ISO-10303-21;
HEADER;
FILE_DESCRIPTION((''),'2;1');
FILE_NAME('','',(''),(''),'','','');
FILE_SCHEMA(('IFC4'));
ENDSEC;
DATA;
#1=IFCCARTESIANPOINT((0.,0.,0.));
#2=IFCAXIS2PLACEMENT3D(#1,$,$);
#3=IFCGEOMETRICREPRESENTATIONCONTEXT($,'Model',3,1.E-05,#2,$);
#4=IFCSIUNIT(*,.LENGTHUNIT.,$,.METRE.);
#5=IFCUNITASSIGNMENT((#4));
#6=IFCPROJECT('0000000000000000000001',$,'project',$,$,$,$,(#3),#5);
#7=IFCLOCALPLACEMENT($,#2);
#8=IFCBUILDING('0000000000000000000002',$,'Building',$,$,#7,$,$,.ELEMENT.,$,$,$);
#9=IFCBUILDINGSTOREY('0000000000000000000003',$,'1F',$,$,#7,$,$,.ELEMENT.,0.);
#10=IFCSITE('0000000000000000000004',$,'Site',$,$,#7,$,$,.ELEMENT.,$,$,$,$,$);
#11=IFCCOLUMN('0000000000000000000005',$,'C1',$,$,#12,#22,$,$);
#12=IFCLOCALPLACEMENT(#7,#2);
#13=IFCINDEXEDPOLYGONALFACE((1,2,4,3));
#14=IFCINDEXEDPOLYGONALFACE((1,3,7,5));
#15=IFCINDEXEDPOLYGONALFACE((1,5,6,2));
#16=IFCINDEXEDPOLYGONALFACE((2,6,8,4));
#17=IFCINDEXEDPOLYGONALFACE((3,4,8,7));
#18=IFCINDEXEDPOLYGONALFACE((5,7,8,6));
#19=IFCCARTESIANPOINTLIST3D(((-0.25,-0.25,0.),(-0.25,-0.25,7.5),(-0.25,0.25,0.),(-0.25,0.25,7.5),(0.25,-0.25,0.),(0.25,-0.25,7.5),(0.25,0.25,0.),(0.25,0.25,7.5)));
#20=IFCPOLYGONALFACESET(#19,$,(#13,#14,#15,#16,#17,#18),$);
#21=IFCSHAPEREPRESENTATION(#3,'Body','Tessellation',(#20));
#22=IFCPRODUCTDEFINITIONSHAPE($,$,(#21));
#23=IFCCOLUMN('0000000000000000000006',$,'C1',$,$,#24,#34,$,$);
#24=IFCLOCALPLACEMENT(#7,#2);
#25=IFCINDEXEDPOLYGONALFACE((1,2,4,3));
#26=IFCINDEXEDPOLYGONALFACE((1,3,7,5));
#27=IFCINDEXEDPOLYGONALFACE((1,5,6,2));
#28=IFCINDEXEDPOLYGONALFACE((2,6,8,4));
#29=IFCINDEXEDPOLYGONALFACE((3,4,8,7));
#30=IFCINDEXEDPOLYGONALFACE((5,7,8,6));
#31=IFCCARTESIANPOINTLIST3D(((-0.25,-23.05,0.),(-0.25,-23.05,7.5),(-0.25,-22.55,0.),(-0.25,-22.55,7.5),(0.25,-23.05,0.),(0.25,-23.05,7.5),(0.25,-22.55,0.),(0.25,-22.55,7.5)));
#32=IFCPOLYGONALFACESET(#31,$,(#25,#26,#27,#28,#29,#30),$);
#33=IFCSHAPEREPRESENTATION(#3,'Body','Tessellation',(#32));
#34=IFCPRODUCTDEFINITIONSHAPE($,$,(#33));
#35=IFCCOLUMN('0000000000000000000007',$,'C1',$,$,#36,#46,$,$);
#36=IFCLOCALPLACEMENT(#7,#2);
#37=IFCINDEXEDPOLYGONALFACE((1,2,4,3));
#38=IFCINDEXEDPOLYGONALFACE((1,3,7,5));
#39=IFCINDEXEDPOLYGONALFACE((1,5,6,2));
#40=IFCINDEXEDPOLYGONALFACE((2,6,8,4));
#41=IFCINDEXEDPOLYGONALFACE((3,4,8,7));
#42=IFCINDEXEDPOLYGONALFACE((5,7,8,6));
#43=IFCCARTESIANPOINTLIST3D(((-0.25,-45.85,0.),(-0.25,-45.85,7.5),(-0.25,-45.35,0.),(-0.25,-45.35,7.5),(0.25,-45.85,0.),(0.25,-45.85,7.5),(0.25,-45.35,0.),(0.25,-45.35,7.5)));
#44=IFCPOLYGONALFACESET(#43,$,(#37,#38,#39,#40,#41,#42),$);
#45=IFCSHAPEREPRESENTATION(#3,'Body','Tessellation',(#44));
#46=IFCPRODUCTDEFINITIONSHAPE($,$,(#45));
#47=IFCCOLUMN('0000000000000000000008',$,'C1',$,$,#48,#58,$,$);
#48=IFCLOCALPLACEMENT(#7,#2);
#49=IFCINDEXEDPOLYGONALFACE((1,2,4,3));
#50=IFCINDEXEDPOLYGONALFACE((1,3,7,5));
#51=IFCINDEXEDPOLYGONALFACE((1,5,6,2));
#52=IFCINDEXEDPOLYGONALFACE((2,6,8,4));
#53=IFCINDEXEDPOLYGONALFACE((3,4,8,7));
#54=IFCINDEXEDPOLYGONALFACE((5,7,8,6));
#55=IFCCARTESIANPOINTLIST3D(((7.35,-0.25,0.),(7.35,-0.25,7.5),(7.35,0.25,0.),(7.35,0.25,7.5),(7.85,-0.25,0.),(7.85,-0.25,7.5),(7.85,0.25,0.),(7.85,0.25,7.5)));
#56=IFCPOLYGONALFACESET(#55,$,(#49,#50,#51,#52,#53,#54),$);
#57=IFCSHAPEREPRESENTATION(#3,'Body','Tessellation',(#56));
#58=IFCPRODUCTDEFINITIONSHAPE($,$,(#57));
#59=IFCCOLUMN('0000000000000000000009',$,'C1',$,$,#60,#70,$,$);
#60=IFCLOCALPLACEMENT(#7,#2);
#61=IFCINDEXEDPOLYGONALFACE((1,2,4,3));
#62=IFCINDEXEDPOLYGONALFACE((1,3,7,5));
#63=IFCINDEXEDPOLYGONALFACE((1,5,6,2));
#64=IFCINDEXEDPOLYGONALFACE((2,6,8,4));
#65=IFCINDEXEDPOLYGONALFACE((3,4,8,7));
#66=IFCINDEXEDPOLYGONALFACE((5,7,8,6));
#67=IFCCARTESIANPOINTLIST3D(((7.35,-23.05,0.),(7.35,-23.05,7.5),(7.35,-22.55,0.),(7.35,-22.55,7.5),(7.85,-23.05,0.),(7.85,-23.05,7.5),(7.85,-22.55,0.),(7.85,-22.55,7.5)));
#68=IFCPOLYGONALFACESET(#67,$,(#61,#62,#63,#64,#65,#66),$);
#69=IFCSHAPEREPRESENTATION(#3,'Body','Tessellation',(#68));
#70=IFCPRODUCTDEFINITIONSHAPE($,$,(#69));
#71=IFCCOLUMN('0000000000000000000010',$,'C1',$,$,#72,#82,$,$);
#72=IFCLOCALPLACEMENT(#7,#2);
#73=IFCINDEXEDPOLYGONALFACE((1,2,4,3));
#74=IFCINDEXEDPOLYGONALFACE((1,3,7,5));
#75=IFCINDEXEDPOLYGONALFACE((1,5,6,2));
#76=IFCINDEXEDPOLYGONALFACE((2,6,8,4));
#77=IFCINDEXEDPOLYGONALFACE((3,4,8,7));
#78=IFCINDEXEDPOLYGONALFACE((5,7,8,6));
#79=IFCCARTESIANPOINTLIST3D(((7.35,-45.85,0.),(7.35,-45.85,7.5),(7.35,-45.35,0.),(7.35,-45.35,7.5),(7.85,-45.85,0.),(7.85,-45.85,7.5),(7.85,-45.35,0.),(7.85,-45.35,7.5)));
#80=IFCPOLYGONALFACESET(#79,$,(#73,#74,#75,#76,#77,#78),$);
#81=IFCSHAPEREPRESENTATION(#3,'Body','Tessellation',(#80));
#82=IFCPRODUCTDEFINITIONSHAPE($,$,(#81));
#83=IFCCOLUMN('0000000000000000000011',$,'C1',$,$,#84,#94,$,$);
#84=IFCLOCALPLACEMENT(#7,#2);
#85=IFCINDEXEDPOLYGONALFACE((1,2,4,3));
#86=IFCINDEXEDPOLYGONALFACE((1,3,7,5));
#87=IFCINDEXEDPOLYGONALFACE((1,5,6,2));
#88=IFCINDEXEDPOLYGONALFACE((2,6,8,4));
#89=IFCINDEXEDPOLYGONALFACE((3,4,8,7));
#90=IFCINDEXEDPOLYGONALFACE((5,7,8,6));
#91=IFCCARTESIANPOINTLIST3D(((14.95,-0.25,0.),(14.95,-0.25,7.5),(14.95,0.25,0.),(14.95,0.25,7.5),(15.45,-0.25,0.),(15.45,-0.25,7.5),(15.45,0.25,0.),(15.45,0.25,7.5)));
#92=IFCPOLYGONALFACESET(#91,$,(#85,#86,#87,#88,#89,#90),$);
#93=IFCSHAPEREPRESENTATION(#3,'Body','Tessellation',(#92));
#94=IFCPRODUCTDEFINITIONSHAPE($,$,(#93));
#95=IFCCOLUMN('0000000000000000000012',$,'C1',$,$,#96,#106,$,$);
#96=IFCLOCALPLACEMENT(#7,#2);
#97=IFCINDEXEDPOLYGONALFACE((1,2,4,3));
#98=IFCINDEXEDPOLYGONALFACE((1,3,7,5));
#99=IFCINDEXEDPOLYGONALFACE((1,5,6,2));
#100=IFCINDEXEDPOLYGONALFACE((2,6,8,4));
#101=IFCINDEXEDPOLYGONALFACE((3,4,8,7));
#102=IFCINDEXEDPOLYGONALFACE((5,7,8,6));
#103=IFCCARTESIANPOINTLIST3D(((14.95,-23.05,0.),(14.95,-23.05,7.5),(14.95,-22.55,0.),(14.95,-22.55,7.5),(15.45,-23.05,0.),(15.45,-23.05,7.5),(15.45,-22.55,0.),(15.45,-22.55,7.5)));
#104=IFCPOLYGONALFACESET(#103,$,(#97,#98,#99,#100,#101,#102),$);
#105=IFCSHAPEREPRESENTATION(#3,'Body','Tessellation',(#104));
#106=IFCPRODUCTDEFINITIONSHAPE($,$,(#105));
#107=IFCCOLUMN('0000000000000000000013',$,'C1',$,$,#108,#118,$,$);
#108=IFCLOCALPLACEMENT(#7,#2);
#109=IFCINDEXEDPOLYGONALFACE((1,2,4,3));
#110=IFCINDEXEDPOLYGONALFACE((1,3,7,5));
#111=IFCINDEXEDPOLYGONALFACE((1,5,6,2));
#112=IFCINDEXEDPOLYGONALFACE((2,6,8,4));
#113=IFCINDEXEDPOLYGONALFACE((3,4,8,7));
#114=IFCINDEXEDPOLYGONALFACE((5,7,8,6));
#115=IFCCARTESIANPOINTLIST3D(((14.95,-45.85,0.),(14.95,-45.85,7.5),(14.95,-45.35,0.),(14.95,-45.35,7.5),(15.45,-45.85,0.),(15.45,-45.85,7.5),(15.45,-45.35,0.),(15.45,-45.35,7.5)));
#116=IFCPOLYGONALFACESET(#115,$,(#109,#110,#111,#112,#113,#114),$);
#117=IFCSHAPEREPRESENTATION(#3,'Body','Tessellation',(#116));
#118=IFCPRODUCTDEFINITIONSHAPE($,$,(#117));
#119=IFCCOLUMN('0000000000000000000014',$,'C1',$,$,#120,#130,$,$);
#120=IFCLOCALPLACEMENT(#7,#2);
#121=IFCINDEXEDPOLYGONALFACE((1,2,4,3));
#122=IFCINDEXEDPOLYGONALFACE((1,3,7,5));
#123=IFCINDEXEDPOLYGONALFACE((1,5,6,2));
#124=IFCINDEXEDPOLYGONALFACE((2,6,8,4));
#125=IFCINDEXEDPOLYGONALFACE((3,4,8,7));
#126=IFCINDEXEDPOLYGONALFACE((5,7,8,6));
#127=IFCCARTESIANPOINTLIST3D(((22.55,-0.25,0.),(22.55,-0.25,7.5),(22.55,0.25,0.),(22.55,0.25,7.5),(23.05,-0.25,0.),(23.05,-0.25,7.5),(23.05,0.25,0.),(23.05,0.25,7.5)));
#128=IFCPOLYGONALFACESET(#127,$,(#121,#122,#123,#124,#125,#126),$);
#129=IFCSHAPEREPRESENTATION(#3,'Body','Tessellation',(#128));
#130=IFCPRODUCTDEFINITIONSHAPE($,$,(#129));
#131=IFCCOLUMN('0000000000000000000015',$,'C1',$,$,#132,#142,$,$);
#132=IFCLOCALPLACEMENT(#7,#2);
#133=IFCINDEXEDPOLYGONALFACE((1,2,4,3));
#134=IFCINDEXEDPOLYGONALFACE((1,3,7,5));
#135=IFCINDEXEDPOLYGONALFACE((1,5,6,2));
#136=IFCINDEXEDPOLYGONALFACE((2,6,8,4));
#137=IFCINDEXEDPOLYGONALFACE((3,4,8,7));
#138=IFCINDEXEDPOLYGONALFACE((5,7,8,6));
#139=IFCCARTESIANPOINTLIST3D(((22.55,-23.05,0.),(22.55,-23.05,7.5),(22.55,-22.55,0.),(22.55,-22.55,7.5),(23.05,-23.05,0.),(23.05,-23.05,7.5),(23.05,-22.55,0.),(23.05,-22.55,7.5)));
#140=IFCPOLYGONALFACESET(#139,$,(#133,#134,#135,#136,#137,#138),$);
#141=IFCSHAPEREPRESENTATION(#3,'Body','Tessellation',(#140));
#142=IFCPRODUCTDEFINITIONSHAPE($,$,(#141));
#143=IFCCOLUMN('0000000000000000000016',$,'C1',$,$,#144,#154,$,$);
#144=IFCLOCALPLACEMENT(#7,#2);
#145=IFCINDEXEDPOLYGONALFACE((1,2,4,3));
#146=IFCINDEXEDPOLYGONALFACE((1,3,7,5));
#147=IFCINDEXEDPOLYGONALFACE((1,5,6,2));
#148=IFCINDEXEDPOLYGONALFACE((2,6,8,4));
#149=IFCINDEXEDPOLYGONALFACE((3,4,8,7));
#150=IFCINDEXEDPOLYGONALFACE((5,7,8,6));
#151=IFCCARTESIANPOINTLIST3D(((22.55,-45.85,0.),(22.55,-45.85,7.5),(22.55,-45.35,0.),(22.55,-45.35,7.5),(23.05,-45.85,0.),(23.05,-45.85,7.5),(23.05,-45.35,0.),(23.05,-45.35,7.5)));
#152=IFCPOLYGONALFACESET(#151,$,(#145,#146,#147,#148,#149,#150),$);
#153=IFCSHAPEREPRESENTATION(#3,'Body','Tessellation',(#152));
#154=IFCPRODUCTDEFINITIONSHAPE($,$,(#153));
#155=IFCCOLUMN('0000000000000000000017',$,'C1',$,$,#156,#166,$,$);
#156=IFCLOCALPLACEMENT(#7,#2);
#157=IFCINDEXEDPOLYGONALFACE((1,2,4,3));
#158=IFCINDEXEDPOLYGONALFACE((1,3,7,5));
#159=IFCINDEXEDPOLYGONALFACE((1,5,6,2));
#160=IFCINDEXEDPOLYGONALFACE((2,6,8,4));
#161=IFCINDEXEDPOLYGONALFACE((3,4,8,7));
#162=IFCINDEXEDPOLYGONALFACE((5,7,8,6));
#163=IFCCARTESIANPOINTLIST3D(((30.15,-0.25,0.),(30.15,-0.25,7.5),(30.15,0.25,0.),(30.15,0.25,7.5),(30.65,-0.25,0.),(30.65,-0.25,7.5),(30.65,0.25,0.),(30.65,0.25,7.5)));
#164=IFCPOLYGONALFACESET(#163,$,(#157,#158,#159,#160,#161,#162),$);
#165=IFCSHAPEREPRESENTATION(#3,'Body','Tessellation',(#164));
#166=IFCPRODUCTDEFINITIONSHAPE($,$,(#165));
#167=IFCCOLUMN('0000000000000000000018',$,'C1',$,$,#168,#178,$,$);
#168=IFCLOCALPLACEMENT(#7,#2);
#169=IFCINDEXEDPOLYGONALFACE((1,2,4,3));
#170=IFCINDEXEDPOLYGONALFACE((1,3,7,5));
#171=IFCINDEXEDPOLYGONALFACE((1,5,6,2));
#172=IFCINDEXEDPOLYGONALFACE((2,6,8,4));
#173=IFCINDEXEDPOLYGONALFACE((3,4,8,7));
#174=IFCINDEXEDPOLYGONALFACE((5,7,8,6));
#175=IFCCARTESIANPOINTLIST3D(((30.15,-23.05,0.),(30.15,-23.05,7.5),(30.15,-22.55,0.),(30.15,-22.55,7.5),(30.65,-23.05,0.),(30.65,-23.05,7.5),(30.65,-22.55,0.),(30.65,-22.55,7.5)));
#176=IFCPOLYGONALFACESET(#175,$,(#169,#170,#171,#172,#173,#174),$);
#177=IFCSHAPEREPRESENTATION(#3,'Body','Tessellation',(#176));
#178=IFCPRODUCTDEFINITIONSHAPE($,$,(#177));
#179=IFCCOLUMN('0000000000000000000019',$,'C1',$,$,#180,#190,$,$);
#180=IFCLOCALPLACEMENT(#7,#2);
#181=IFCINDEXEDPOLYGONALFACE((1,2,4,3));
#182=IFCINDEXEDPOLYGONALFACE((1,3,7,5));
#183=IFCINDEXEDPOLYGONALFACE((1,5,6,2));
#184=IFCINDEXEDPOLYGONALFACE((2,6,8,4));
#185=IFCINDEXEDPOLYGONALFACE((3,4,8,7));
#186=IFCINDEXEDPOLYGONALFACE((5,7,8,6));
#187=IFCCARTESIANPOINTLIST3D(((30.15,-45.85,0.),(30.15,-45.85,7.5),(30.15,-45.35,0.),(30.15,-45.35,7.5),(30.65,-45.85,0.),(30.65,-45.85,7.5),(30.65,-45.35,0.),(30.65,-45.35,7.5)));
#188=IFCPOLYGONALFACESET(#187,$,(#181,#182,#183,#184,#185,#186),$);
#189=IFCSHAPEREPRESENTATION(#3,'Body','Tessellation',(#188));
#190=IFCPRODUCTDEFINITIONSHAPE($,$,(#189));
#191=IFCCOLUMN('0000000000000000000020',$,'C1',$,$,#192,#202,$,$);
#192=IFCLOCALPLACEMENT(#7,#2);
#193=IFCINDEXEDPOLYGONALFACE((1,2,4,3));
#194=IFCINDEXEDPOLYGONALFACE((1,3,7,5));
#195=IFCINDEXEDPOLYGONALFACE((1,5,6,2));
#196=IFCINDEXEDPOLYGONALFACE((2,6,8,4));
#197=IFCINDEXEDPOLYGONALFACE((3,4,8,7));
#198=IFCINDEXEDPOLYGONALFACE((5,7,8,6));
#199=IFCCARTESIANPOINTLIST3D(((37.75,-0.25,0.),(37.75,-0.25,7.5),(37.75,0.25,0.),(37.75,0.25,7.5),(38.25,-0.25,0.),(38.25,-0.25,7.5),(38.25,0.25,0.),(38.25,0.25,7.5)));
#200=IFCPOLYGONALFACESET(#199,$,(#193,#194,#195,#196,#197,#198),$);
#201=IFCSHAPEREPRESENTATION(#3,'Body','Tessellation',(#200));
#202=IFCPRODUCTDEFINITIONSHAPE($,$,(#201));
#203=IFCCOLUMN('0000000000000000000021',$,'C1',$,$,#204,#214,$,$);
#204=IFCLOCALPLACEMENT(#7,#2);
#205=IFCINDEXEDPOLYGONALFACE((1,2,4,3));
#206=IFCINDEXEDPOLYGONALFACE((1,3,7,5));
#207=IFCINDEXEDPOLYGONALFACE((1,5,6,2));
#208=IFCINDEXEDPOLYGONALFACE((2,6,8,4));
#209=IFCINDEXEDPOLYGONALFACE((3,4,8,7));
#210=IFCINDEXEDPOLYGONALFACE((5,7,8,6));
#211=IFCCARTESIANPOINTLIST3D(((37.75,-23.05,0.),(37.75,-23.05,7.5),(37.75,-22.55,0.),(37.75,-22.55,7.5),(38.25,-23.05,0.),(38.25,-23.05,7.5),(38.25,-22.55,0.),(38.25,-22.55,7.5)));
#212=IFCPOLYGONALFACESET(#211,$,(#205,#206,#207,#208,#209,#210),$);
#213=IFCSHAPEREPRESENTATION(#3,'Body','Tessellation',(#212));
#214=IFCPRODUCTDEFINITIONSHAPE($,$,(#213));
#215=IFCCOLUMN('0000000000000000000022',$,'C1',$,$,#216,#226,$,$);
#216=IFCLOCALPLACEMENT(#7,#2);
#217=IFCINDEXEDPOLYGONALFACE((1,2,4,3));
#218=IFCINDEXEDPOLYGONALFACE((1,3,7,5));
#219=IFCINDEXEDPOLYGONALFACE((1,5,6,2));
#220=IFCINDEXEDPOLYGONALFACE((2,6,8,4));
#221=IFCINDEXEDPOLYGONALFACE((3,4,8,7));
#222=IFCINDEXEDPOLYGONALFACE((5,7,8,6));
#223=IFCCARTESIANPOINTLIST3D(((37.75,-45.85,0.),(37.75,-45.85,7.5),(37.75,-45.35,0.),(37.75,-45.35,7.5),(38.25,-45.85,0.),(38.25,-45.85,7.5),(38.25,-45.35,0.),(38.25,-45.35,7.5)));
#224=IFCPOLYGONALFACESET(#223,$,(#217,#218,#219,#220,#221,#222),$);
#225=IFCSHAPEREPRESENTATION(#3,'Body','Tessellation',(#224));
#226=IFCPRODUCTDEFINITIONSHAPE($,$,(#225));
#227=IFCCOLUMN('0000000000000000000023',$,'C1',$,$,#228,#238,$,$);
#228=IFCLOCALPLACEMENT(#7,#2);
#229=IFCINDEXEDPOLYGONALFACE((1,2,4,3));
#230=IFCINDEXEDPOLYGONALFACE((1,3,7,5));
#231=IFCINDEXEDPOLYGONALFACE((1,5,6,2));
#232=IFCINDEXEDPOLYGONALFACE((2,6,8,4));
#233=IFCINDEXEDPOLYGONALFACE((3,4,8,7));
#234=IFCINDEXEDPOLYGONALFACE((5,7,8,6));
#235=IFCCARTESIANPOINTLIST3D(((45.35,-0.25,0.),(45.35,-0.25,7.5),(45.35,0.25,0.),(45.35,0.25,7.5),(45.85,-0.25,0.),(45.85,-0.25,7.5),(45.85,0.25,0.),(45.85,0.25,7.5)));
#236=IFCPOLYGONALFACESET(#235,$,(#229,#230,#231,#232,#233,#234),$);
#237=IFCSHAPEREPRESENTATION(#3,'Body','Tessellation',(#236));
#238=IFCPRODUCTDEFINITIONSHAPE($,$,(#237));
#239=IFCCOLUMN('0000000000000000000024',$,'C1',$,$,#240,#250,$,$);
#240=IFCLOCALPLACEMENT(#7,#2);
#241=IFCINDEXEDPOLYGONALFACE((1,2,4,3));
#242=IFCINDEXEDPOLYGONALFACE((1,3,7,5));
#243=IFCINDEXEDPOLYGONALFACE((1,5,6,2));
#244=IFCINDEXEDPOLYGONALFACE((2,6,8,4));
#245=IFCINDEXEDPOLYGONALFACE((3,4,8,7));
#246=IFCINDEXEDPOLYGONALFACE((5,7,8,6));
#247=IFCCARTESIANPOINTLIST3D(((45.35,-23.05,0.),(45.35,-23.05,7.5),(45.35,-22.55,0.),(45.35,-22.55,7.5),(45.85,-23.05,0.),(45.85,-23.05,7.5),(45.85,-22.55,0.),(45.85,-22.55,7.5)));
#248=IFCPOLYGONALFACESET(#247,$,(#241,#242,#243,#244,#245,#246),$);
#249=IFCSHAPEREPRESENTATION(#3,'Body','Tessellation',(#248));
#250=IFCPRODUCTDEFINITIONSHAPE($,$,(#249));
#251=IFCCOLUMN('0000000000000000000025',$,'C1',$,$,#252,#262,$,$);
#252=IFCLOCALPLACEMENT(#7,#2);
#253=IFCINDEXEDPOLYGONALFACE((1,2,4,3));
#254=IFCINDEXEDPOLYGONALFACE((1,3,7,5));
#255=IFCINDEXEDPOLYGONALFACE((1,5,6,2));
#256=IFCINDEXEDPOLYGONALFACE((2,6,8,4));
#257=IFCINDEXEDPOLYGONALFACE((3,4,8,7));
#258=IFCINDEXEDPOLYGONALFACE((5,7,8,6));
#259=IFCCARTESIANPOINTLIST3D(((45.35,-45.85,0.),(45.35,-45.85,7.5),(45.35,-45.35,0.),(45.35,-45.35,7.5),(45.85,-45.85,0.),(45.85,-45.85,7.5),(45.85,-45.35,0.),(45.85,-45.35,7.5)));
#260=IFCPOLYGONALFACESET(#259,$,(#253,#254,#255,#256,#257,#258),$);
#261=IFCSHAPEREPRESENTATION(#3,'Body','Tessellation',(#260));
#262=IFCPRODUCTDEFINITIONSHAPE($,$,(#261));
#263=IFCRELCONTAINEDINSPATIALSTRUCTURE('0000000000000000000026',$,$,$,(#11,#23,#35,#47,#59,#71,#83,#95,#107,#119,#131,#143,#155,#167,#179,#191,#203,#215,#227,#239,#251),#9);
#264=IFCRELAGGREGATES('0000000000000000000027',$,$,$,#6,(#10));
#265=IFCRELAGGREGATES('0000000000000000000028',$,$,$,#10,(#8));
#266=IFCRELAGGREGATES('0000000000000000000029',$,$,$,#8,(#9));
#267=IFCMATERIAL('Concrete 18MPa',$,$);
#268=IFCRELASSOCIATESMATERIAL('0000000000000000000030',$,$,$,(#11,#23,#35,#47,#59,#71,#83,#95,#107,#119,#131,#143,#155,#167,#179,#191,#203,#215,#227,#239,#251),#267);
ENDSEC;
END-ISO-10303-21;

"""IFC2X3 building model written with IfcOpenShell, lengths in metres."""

from ifc_helpers import new_model, si_unit, frame, origin, origin_2d, place, context, project, spatial, rectangle, extrude, material, element, save


model = new_model("IFC2X3")

# Units and contexts
model_context = context("Model", 3, precision=1e-05, world=origin())
ifc_project = project(units=[si_unit("LENGTHUNIT", "METRE")], contexts=[model_context])

# Site, building, storey
placement = place(None, origin())
site = spatial("IfcSite", under=ifc_project, at=placement, Name="Site", CompositionType="ELEMENT")
building = spatial("IfcBuilding", under=site, at=placement, Name="Building", CompositionType="ELEMENT")
storey = spatial("IfcBuildingStorey", under=building, at=placement, Name="1F", CompositionType="ELEMENT", Elevation=0.0)

# Columns
ifc_material = material(Name="Concrete 18MPa")
for number, where, name in (
    (1, (0.0, 0.0, 0.0), "C1"),
    (2, (0.0, -22.8, 0.0), "C1"),
    (3, (0.0, -45.6, 0.0), "C1"),
    (4, (7.6, 0.0, 0.0), "C1"),
    (5, (7.6, -22.8, 0.0), "C1"),
    (6, (7.6, -45.6, 0.0), "C1"),
    (7, (15.2, 0.0, 0.0), "C1"),
    (8, (15.2, -22.8, 0.0), "C1"),
    (9, (15.2, -45.6, 0.0), "C1"),
    (10, (22.8, 0.0, 0.0), "C1"),
    (11, (22.8, -22.8, 0.0), "C1"),
    (12, (22.8, -45.6, 0.0), "C1"),
    (13, (30.4, 0.0, 0.0), "C1"),
    (14, (30.4, -22.8, 0.0), "C1"),
    (15, (30.4, -45.6, 0.0), "C1"),
    (16, (38.0, 0.0, 0.0), "C1"),
    (17, (38.0, -22.8, 0.0), "C1"),
    (18, (38.0, -45.6, 0.0), "C1"),
    (19, (45.6, 0.0, 0.0), "C1"),
    (20, (45.6, -22.8, 0.0), "C1"),
    (21, (45.6, -45.6, 0.0), "C1"),
):
    element("IfcColumn", number, at=place(None, frame(where)), inside=storey, material=ifc_material, Name=name, context=model_context, shape_type="SweptSolid", body=[
        extrude(rectangle(XDim=0.5, YDim=0.5, at=origin_2d()), origin(), (0.0, 0.0, 1.0), 7.5),
    ])

save(model, "model.ifc")
